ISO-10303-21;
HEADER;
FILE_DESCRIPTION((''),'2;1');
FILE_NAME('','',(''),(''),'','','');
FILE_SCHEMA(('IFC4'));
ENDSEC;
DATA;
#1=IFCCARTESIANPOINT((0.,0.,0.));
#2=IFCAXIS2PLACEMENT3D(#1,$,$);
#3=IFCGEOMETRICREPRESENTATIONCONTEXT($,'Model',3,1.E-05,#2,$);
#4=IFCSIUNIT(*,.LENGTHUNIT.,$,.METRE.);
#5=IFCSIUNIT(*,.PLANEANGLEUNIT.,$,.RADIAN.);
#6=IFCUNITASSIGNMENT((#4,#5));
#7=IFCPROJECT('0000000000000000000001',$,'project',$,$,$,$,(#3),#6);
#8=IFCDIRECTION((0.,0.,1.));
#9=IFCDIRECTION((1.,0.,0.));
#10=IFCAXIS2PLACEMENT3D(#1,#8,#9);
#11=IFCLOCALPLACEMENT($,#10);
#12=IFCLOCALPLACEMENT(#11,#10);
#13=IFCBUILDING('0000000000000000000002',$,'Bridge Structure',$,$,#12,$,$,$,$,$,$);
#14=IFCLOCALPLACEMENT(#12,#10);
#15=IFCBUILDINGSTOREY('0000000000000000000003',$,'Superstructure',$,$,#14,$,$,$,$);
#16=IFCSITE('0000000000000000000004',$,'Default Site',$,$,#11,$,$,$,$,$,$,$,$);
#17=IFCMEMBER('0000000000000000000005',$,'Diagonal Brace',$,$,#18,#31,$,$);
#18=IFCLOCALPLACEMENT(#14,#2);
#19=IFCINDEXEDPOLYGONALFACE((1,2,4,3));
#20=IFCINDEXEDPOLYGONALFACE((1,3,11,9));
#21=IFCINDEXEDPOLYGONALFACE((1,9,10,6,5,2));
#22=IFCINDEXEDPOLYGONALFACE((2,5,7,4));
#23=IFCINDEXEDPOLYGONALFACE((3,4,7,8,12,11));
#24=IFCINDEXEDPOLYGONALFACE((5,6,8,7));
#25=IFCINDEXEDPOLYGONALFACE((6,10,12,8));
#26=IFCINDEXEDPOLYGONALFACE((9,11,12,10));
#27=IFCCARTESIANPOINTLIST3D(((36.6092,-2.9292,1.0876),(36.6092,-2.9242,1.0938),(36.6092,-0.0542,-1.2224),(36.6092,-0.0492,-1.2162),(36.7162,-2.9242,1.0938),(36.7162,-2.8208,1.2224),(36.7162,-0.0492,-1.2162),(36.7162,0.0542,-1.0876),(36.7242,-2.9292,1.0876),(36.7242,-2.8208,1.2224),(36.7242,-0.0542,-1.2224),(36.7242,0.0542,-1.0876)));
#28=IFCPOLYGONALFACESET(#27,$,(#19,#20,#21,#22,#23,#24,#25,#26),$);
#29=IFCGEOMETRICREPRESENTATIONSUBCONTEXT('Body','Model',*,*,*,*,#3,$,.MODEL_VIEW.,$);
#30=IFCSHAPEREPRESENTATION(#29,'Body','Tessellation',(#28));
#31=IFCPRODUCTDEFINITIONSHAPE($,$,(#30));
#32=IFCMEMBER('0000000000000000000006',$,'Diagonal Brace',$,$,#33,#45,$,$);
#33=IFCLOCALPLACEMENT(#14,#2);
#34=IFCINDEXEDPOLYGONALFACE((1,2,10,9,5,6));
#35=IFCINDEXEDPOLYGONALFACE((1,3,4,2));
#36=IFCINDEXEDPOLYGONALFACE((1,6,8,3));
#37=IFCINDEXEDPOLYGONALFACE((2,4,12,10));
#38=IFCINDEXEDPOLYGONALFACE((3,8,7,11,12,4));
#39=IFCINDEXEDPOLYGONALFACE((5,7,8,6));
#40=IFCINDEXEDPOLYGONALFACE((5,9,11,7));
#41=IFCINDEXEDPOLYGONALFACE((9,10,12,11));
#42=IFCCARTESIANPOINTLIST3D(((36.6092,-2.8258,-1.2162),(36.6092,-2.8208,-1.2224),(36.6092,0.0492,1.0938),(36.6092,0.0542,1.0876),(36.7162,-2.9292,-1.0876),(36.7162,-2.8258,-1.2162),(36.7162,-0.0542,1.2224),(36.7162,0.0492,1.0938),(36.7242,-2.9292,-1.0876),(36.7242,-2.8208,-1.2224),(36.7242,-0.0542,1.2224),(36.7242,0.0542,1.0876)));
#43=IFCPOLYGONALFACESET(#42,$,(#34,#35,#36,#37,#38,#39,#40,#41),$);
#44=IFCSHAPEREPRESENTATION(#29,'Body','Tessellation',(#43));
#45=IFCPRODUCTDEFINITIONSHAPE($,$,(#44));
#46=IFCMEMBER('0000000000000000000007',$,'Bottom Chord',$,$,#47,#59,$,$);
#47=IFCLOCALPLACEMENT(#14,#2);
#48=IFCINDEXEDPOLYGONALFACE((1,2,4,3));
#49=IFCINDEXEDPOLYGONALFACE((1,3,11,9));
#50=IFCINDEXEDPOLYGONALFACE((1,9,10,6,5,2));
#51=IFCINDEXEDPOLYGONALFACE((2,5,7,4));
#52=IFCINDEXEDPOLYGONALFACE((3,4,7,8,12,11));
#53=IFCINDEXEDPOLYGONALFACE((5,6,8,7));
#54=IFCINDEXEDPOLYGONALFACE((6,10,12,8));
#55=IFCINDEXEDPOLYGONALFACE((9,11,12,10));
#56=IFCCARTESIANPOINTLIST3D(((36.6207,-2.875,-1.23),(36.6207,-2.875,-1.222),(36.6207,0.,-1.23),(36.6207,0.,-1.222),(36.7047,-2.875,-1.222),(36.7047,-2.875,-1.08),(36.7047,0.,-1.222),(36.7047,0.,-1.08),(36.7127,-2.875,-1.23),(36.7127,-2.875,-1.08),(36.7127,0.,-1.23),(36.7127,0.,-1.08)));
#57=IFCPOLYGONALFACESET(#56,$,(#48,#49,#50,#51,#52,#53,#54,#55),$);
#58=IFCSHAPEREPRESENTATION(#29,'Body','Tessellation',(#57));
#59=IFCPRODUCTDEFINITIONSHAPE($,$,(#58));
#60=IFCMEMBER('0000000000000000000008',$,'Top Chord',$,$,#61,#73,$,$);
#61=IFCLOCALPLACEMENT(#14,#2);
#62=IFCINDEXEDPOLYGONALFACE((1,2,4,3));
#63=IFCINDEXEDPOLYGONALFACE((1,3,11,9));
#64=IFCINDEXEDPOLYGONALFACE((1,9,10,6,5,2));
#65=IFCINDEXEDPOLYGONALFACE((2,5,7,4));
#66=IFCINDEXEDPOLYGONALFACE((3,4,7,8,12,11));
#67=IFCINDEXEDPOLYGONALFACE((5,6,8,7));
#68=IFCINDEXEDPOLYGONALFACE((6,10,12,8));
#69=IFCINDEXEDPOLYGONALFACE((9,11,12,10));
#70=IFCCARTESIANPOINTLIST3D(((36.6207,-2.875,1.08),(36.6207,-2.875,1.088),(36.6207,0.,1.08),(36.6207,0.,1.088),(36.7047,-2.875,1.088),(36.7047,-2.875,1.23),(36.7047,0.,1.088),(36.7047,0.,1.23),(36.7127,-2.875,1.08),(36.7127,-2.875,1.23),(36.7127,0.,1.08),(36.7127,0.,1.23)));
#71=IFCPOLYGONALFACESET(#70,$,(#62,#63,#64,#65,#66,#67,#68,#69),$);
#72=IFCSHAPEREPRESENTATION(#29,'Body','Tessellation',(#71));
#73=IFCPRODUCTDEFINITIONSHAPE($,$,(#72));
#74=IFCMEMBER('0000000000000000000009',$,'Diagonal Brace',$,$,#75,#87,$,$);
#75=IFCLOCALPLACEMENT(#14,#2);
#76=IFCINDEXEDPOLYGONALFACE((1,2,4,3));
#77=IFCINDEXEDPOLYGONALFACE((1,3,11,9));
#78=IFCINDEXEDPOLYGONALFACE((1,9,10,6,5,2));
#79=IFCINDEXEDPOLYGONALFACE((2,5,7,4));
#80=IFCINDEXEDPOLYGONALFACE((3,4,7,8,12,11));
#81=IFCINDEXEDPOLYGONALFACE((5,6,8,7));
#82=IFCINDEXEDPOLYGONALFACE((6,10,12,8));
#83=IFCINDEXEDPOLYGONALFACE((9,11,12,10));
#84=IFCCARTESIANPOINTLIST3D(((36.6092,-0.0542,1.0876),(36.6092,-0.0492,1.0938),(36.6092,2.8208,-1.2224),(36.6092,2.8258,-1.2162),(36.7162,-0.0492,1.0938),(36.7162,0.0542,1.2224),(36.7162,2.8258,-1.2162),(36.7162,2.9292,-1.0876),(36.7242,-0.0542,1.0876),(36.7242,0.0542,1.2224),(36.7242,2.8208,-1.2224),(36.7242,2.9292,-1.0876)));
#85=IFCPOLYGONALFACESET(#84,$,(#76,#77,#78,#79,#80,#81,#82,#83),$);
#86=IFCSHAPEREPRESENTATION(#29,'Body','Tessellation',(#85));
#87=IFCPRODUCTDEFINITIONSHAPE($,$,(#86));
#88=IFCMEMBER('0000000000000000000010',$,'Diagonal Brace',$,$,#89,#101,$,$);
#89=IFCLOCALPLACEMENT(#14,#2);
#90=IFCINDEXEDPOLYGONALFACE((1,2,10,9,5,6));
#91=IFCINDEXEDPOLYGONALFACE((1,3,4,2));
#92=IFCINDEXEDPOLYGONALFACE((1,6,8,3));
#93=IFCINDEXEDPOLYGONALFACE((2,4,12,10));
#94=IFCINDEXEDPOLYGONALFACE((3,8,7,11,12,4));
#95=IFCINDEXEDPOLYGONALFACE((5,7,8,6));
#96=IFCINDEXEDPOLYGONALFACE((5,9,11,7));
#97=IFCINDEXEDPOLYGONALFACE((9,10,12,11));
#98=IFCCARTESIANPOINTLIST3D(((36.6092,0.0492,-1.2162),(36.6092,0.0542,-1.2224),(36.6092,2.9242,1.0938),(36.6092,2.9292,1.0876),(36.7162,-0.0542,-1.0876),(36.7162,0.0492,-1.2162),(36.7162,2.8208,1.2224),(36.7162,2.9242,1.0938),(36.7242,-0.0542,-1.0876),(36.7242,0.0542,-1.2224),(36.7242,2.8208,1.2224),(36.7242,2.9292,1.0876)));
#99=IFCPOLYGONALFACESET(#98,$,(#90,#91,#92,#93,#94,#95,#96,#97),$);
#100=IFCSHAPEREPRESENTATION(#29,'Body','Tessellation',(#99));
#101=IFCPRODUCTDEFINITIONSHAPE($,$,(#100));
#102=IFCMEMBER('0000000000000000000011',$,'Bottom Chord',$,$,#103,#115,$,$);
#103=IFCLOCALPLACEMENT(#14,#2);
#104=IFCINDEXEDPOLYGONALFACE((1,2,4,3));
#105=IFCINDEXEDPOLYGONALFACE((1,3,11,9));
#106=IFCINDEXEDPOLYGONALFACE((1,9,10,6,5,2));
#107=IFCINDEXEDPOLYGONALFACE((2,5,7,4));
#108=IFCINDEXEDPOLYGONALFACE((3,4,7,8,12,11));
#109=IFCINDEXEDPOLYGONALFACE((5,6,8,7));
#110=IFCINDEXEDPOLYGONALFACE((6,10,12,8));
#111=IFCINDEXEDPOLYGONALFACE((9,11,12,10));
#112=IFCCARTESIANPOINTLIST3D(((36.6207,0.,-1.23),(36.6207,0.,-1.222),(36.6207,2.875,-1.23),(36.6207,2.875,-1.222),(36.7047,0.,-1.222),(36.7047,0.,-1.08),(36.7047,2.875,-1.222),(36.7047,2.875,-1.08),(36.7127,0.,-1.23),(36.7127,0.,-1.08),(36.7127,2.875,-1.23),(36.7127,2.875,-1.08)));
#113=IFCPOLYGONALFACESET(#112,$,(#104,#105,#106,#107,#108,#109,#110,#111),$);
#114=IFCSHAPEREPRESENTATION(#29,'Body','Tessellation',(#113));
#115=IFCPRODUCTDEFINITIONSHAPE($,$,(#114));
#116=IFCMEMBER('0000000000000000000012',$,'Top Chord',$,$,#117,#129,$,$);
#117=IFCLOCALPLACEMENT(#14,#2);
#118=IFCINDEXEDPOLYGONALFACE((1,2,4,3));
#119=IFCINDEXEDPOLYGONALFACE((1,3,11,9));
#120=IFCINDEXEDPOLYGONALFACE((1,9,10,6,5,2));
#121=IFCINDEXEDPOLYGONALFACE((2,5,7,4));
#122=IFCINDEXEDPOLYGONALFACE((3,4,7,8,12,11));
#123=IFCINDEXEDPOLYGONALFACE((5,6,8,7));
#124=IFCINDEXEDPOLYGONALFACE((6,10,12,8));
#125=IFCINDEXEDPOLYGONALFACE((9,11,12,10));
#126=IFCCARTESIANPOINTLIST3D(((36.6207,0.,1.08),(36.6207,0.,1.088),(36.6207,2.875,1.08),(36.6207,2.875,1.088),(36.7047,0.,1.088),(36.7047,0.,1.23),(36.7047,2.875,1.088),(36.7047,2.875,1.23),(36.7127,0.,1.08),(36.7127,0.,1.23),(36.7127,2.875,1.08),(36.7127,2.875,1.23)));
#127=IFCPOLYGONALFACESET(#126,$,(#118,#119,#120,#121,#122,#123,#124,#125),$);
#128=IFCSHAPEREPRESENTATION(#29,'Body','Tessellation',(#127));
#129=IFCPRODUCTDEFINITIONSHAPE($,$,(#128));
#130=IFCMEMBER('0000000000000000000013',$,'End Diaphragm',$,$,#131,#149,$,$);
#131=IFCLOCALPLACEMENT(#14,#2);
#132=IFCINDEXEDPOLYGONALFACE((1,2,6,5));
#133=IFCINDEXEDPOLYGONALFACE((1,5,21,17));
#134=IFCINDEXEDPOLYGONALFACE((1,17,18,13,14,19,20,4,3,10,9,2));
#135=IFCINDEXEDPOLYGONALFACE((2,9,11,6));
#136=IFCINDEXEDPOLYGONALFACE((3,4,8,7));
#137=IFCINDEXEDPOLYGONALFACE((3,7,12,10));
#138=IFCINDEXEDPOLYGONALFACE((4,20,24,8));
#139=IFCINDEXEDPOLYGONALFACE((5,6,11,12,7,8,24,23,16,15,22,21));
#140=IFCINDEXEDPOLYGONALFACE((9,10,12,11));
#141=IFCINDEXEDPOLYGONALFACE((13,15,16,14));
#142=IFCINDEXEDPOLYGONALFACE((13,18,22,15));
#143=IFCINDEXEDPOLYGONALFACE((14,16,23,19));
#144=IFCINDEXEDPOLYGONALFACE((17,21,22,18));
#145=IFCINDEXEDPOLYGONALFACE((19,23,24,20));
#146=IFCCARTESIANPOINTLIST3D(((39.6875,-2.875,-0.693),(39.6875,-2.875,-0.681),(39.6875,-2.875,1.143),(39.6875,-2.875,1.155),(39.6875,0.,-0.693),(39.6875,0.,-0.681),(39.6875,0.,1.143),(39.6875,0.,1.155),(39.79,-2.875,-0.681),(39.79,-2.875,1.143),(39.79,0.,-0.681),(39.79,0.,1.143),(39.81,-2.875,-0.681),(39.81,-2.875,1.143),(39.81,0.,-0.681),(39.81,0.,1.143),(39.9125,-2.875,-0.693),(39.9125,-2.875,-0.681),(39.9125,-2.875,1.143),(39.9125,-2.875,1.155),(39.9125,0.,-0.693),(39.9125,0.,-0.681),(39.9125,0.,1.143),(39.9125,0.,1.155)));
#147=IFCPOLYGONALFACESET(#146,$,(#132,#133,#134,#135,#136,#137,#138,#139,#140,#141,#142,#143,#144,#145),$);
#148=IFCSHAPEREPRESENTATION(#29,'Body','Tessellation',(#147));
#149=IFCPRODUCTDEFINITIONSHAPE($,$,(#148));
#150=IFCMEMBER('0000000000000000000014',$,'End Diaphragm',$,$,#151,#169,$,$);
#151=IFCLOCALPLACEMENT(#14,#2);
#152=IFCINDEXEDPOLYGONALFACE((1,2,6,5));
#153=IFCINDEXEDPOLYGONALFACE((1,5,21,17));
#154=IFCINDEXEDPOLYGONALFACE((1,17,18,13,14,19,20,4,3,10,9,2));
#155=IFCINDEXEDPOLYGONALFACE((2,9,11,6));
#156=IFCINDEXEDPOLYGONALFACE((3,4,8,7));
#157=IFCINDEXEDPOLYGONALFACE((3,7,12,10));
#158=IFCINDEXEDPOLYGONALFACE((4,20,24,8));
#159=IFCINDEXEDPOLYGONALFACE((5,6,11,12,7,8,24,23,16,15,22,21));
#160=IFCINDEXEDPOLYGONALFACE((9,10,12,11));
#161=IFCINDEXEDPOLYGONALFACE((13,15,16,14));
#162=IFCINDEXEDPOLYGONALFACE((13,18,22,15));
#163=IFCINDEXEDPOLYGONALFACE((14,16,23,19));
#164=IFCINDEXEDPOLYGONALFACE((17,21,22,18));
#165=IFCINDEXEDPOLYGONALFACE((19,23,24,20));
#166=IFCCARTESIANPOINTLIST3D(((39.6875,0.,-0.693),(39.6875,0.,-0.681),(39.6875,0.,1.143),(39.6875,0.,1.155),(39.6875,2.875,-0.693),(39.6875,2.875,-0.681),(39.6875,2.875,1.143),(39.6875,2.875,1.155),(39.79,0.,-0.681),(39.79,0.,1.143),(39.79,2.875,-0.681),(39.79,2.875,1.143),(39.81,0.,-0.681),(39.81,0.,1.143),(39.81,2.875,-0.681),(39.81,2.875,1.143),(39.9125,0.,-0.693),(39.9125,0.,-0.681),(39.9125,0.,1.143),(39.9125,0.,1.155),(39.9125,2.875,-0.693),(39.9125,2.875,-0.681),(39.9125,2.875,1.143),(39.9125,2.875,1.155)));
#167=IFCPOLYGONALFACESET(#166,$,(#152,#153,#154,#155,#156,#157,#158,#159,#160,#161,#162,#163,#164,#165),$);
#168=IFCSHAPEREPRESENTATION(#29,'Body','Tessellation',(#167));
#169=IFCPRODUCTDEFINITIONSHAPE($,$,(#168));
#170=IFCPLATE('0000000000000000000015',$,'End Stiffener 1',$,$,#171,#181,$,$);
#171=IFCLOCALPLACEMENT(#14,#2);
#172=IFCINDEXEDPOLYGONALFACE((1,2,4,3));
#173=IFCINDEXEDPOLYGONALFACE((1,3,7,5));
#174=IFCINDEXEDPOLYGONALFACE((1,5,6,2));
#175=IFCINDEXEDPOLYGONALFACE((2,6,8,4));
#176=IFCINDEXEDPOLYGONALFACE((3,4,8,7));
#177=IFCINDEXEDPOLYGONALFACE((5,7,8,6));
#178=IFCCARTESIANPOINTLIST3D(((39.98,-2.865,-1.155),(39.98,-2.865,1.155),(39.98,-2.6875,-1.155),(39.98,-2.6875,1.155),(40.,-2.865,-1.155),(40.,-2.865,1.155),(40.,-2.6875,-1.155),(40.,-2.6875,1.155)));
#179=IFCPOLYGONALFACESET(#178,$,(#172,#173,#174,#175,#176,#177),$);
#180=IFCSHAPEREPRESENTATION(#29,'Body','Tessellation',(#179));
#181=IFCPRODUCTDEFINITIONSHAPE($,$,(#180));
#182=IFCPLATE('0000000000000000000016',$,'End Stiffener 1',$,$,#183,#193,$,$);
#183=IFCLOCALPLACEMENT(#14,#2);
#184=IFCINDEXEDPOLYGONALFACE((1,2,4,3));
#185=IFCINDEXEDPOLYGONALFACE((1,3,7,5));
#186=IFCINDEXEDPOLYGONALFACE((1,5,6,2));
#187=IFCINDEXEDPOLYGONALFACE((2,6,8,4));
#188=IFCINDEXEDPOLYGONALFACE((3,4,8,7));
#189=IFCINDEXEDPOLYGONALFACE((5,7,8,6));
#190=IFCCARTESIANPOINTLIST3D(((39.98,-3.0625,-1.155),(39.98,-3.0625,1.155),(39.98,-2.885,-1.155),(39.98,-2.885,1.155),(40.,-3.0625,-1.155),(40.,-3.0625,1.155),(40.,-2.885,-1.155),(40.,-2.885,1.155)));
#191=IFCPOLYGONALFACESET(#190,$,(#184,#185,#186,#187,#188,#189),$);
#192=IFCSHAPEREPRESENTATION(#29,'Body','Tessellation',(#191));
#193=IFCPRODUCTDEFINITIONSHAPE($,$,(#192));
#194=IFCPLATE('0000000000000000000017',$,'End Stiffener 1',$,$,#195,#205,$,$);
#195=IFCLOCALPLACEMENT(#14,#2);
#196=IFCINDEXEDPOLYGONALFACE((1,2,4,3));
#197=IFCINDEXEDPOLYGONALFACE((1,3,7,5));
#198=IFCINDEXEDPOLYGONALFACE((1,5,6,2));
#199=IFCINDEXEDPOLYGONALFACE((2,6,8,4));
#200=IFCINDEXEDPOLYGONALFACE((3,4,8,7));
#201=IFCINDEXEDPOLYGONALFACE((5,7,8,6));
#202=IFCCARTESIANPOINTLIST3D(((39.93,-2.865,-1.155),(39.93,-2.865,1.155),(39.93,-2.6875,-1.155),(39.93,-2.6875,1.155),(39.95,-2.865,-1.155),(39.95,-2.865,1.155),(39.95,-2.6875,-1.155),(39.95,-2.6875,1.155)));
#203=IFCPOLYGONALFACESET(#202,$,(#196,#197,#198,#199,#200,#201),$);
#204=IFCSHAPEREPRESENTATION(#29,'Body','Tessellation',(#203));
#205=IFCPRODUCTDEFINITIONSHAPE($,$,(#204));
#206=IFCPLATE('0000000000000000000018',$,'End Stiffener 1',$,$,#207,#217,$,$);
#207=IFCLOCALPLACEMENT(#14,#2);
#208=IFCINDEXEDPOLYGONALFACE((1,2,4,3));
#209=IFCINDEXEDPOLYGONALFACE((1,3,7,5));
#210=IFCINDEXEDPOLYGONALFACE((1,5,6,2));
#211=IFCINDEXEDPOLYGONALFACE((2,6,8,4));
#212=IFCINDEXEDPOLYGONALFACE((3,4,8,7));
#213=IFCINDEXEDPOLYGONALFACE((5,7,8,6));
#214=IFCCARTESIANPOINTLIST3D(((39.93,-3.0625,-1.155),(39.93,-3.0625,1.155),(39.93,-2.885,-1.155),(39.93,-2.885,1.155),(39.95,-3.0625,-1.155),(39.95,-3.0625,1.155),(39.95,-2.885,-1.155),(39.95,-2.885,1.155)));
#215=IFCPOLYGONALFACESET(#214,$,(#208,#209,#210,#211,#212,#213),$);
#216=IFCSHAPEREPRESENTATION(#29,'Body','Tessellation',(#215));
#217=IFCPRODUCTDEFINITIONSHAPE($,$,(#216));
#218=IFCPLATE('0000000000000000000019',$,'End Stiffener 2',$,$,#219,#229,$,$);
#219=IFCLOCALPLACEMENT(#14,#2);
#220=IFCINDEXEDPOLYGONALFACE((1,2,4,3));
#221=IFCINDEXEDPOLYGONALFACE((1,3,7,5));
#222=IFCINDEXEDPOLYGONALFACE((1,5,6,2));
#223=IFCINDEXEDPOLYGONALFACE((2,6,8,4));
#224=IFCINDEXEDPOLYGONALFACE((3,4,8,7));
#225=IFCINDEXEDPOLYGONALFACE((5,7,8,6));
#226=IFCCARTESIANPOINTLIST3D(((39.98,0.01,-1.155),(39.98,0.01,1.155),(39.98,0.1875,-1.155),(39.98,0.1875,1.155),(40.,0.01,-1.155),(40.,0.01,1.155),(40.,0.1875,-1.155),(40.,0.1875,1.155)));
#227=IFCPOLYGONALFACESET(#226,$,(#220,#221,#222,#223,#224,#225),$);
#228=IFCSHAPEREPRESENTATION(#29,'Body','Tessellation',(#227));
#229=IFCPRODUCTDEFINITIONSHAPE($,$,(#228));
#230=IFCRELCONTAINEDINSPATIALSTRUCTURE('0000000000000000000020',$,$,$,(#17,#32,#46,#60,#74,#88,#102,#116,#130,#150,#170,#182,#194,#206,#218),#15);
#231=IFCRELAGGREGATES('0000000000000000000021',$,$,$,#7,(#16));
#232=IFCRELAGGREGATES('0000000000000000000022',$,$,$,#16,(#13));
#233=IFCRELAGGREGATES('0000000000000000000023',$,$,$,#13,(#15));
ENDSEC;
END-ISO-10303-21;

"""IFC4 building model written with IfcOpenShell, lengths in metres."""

from ifc_helpers import new_model, si_unit, frame, origin, origin_with_axes, origin_2d_with_axis, place, context, subcontext, project, spatial, rectangle, i_section, l_section, extrude, element, save


model = new_model("IFC4")

# Units and contexts
model_context = context("Model", 3, precision=1e-05, world=origin())
body_context = subcontext(model_context, "Body", "Model", "MODEL_VIEW")
ifc_project = project(units=[si_unit("LENGTHUNIT", "METRE"), si_unit("PLANEANGLEUNIT", "RADIAN")], contexts=[model_context])

# Site, building, storey
site_placement = place(None, origin_with_axes())
site = spatial("IfcSite", under=ifc_project, at=site_placement, Name="Default Site")
building_placement = place(site_placement, origin_with_axes())
building = spatial("IfcBuilding", under=site, at=building_placement, Name="Bridge Structure")
storey_placement = place(building_placement, origin_with_axes())
storey = spatial("IfcBuildingStorey", under=building, at=storey_placement, Name="Superstructure")

# Members
for number, where, z_axis, x_axis, name in (
    (1, (36.6667, -2.875, 1.155), (0.0, 0.779544, -0.626347), (-1.0, 0.0, 0.0), "Diagonal Brace"),
    (2, (36.6667, -2.875, -1.155), (0.0, 0.779544, 0.626347), (-1.0, 0.0, 0.0), "Diagonal Brace"),
):
    element("IfcMember", number, at=place(storey_placement, frame(where, z_axis=z_axis, x_axis=x_axis)), inside=storey, Name=name, context=body_context, shape_type="SweptSolid", body=[
        extrude(l_section(Depth=0.173, Width=0.115, Thickness=0.008, at=origin_2d_with_axis()), origin_with_axes(), (0.0, 0.0, 1.0), 3.6881),
    ])
for number, where, z_axis, x_axis, name in (
    (3, (36.6667, -2.875, -1.155), (0.0, 1.0, 0.0), (-1.0, 0.0, 0.0), "Bottom Chord"),
    (4, (36.6667, -2.875, 1.155), (0.0, 1.0, 0.0), (-1.0, 0.0, 0.0), "Top Chord"),
):
    element("IfcMember", number, at=place(storey_placement, frame(where, z_axis=z_axis, x_axis=x_axis)), inside=storey, Name=name, context=body_context, shape_type="SweptSolid", body=[
        extrude(l_section(Depth=0.15, Width=0.092, Thickness=0.008, at=origin_2d_with_axis()), origin_with_axes(), (0.0, 0.0, 1.0), 2.875),
    ])
for number, where, z_axis, x_axis, name in (
    (5, (36.6667, 0.0, 1.155), (0.0, 0.779544, -0.626347), (-1.0, 0.0, 0.0), "Diagonal Brace"),
    (6, (36.6667, 0.0, -1.155), (0.0, 0.779544, 0.626347), (-1.0, 0.0, 0.0), "Diagonal Brace"),
):
    element("IfcMember", number, at=place(storey_placement, frame(where, z_axis=z_axis, x_axis=x_axis)), inside=storey, Name=name, context=body_context, shape_type="SweptSolid", body=[
        extrude(l_section(Depth=0.173, Width=0.115, Thickness=0.008, at=origin_2d_with_axis()), origin_with_axes(), (0.0, 0.0, 1.0), 3.6881),
    ])
for number, where, z_axis, x_axis, name in (
    (7, (36.6667, 0.0, -1.155), (0.0, 1.0, 0.0), (-1.0, 0.0, 0.0), "Bottom Chord"),
    (8, (36.6667, 0.0, 1.155), (0.0, 1.0, 0.0), (-1.0, 0.0, 0.0), "Top Chord"),
):
    element("IfcMember", number, at=place(storey_placement, frame(where, z_axis=z_axis, x_axis=x_axis)), inside=storey, Name=name, context=body_context, shape_type="SweptSolid", body=[
        extrude(l_section(Depth=0.15, Width=0.092, Thickness=0.008, at=origin_2d_with_axis()), origin_with_axes(), (0.0, 0.0, 1.0), 2.875),
    ])
for number, where, z_axis, x_axis, name in (
    (9, (39.8, -2.875, 0.231), (0.0, 1.0, 0.0), (-1.0, 0.0, 0.0), "End Diaphragm"),
    (10, (39.8, 0.0, 0.231), (0.0, 1.0, 0.0), (-1.0, 0.0, 0.0), "End Diaphragm"),
):
    element("IfcMember", number, at=place(storey_placement, frame(where, z_axis=z_axis, x_axis=x_axis)), inside=storey, Name=name, context=body_context, shape_type="SweptSolid", body=[
        extrude(i_section(OverallWidth=0.225, OverallDepth=1.848, WebThickness=0.02, FlangeThickness=0.012, at=origin_2d_with_axis()), origin_with_axes(), (0.0, 0.0, 1.0), 2.875),
    ])

# Plates
for number, where, z_axis, x_axis, name in (
    (11, (39.99, -2.7763, -1.155), (0.0, 0.0, 1.0), (1.0, 0.0, 0.0), "End Stiffener 1"),
    (12, (39.99, -2.9737, -1.155), (0.0, 0.0, 1.0), (1.0, 0.0, 0.0), "End Stiffener 1"),
    (13, (39.94, -2.7763, -1.155), (0.0, 0.0, 1.0), (1.0, 0.0, 0.0), "End Stiffener 1"),
    (14, (39.94, -2.9737, -1.155), (0.0, 0.0, 1.0), (1.0, 0.0, 0.0), "End Stiffener 1"),
    (15, (39.99, 0.0988, -1.155), (0.0, 0.0, 1.0), (1.0, 0.0, 0.0), "End Stiffener 2"),
):
    element("IfcPlate", number, at=place(storey_placement, frame(where, z_axis=z_axis, x_axis=x_axis)), inside=storey, Name=name, context=body_context, shape_type="SweptSolid", body=[
        extrude(rectangle(XDim=0.02, YDim=0.1775, at=origin_2d_with_axis()), origin_with_axes(), (0.0, 0.0, 1.0), 2.31),
    ])

save(model, "model.ifc")
